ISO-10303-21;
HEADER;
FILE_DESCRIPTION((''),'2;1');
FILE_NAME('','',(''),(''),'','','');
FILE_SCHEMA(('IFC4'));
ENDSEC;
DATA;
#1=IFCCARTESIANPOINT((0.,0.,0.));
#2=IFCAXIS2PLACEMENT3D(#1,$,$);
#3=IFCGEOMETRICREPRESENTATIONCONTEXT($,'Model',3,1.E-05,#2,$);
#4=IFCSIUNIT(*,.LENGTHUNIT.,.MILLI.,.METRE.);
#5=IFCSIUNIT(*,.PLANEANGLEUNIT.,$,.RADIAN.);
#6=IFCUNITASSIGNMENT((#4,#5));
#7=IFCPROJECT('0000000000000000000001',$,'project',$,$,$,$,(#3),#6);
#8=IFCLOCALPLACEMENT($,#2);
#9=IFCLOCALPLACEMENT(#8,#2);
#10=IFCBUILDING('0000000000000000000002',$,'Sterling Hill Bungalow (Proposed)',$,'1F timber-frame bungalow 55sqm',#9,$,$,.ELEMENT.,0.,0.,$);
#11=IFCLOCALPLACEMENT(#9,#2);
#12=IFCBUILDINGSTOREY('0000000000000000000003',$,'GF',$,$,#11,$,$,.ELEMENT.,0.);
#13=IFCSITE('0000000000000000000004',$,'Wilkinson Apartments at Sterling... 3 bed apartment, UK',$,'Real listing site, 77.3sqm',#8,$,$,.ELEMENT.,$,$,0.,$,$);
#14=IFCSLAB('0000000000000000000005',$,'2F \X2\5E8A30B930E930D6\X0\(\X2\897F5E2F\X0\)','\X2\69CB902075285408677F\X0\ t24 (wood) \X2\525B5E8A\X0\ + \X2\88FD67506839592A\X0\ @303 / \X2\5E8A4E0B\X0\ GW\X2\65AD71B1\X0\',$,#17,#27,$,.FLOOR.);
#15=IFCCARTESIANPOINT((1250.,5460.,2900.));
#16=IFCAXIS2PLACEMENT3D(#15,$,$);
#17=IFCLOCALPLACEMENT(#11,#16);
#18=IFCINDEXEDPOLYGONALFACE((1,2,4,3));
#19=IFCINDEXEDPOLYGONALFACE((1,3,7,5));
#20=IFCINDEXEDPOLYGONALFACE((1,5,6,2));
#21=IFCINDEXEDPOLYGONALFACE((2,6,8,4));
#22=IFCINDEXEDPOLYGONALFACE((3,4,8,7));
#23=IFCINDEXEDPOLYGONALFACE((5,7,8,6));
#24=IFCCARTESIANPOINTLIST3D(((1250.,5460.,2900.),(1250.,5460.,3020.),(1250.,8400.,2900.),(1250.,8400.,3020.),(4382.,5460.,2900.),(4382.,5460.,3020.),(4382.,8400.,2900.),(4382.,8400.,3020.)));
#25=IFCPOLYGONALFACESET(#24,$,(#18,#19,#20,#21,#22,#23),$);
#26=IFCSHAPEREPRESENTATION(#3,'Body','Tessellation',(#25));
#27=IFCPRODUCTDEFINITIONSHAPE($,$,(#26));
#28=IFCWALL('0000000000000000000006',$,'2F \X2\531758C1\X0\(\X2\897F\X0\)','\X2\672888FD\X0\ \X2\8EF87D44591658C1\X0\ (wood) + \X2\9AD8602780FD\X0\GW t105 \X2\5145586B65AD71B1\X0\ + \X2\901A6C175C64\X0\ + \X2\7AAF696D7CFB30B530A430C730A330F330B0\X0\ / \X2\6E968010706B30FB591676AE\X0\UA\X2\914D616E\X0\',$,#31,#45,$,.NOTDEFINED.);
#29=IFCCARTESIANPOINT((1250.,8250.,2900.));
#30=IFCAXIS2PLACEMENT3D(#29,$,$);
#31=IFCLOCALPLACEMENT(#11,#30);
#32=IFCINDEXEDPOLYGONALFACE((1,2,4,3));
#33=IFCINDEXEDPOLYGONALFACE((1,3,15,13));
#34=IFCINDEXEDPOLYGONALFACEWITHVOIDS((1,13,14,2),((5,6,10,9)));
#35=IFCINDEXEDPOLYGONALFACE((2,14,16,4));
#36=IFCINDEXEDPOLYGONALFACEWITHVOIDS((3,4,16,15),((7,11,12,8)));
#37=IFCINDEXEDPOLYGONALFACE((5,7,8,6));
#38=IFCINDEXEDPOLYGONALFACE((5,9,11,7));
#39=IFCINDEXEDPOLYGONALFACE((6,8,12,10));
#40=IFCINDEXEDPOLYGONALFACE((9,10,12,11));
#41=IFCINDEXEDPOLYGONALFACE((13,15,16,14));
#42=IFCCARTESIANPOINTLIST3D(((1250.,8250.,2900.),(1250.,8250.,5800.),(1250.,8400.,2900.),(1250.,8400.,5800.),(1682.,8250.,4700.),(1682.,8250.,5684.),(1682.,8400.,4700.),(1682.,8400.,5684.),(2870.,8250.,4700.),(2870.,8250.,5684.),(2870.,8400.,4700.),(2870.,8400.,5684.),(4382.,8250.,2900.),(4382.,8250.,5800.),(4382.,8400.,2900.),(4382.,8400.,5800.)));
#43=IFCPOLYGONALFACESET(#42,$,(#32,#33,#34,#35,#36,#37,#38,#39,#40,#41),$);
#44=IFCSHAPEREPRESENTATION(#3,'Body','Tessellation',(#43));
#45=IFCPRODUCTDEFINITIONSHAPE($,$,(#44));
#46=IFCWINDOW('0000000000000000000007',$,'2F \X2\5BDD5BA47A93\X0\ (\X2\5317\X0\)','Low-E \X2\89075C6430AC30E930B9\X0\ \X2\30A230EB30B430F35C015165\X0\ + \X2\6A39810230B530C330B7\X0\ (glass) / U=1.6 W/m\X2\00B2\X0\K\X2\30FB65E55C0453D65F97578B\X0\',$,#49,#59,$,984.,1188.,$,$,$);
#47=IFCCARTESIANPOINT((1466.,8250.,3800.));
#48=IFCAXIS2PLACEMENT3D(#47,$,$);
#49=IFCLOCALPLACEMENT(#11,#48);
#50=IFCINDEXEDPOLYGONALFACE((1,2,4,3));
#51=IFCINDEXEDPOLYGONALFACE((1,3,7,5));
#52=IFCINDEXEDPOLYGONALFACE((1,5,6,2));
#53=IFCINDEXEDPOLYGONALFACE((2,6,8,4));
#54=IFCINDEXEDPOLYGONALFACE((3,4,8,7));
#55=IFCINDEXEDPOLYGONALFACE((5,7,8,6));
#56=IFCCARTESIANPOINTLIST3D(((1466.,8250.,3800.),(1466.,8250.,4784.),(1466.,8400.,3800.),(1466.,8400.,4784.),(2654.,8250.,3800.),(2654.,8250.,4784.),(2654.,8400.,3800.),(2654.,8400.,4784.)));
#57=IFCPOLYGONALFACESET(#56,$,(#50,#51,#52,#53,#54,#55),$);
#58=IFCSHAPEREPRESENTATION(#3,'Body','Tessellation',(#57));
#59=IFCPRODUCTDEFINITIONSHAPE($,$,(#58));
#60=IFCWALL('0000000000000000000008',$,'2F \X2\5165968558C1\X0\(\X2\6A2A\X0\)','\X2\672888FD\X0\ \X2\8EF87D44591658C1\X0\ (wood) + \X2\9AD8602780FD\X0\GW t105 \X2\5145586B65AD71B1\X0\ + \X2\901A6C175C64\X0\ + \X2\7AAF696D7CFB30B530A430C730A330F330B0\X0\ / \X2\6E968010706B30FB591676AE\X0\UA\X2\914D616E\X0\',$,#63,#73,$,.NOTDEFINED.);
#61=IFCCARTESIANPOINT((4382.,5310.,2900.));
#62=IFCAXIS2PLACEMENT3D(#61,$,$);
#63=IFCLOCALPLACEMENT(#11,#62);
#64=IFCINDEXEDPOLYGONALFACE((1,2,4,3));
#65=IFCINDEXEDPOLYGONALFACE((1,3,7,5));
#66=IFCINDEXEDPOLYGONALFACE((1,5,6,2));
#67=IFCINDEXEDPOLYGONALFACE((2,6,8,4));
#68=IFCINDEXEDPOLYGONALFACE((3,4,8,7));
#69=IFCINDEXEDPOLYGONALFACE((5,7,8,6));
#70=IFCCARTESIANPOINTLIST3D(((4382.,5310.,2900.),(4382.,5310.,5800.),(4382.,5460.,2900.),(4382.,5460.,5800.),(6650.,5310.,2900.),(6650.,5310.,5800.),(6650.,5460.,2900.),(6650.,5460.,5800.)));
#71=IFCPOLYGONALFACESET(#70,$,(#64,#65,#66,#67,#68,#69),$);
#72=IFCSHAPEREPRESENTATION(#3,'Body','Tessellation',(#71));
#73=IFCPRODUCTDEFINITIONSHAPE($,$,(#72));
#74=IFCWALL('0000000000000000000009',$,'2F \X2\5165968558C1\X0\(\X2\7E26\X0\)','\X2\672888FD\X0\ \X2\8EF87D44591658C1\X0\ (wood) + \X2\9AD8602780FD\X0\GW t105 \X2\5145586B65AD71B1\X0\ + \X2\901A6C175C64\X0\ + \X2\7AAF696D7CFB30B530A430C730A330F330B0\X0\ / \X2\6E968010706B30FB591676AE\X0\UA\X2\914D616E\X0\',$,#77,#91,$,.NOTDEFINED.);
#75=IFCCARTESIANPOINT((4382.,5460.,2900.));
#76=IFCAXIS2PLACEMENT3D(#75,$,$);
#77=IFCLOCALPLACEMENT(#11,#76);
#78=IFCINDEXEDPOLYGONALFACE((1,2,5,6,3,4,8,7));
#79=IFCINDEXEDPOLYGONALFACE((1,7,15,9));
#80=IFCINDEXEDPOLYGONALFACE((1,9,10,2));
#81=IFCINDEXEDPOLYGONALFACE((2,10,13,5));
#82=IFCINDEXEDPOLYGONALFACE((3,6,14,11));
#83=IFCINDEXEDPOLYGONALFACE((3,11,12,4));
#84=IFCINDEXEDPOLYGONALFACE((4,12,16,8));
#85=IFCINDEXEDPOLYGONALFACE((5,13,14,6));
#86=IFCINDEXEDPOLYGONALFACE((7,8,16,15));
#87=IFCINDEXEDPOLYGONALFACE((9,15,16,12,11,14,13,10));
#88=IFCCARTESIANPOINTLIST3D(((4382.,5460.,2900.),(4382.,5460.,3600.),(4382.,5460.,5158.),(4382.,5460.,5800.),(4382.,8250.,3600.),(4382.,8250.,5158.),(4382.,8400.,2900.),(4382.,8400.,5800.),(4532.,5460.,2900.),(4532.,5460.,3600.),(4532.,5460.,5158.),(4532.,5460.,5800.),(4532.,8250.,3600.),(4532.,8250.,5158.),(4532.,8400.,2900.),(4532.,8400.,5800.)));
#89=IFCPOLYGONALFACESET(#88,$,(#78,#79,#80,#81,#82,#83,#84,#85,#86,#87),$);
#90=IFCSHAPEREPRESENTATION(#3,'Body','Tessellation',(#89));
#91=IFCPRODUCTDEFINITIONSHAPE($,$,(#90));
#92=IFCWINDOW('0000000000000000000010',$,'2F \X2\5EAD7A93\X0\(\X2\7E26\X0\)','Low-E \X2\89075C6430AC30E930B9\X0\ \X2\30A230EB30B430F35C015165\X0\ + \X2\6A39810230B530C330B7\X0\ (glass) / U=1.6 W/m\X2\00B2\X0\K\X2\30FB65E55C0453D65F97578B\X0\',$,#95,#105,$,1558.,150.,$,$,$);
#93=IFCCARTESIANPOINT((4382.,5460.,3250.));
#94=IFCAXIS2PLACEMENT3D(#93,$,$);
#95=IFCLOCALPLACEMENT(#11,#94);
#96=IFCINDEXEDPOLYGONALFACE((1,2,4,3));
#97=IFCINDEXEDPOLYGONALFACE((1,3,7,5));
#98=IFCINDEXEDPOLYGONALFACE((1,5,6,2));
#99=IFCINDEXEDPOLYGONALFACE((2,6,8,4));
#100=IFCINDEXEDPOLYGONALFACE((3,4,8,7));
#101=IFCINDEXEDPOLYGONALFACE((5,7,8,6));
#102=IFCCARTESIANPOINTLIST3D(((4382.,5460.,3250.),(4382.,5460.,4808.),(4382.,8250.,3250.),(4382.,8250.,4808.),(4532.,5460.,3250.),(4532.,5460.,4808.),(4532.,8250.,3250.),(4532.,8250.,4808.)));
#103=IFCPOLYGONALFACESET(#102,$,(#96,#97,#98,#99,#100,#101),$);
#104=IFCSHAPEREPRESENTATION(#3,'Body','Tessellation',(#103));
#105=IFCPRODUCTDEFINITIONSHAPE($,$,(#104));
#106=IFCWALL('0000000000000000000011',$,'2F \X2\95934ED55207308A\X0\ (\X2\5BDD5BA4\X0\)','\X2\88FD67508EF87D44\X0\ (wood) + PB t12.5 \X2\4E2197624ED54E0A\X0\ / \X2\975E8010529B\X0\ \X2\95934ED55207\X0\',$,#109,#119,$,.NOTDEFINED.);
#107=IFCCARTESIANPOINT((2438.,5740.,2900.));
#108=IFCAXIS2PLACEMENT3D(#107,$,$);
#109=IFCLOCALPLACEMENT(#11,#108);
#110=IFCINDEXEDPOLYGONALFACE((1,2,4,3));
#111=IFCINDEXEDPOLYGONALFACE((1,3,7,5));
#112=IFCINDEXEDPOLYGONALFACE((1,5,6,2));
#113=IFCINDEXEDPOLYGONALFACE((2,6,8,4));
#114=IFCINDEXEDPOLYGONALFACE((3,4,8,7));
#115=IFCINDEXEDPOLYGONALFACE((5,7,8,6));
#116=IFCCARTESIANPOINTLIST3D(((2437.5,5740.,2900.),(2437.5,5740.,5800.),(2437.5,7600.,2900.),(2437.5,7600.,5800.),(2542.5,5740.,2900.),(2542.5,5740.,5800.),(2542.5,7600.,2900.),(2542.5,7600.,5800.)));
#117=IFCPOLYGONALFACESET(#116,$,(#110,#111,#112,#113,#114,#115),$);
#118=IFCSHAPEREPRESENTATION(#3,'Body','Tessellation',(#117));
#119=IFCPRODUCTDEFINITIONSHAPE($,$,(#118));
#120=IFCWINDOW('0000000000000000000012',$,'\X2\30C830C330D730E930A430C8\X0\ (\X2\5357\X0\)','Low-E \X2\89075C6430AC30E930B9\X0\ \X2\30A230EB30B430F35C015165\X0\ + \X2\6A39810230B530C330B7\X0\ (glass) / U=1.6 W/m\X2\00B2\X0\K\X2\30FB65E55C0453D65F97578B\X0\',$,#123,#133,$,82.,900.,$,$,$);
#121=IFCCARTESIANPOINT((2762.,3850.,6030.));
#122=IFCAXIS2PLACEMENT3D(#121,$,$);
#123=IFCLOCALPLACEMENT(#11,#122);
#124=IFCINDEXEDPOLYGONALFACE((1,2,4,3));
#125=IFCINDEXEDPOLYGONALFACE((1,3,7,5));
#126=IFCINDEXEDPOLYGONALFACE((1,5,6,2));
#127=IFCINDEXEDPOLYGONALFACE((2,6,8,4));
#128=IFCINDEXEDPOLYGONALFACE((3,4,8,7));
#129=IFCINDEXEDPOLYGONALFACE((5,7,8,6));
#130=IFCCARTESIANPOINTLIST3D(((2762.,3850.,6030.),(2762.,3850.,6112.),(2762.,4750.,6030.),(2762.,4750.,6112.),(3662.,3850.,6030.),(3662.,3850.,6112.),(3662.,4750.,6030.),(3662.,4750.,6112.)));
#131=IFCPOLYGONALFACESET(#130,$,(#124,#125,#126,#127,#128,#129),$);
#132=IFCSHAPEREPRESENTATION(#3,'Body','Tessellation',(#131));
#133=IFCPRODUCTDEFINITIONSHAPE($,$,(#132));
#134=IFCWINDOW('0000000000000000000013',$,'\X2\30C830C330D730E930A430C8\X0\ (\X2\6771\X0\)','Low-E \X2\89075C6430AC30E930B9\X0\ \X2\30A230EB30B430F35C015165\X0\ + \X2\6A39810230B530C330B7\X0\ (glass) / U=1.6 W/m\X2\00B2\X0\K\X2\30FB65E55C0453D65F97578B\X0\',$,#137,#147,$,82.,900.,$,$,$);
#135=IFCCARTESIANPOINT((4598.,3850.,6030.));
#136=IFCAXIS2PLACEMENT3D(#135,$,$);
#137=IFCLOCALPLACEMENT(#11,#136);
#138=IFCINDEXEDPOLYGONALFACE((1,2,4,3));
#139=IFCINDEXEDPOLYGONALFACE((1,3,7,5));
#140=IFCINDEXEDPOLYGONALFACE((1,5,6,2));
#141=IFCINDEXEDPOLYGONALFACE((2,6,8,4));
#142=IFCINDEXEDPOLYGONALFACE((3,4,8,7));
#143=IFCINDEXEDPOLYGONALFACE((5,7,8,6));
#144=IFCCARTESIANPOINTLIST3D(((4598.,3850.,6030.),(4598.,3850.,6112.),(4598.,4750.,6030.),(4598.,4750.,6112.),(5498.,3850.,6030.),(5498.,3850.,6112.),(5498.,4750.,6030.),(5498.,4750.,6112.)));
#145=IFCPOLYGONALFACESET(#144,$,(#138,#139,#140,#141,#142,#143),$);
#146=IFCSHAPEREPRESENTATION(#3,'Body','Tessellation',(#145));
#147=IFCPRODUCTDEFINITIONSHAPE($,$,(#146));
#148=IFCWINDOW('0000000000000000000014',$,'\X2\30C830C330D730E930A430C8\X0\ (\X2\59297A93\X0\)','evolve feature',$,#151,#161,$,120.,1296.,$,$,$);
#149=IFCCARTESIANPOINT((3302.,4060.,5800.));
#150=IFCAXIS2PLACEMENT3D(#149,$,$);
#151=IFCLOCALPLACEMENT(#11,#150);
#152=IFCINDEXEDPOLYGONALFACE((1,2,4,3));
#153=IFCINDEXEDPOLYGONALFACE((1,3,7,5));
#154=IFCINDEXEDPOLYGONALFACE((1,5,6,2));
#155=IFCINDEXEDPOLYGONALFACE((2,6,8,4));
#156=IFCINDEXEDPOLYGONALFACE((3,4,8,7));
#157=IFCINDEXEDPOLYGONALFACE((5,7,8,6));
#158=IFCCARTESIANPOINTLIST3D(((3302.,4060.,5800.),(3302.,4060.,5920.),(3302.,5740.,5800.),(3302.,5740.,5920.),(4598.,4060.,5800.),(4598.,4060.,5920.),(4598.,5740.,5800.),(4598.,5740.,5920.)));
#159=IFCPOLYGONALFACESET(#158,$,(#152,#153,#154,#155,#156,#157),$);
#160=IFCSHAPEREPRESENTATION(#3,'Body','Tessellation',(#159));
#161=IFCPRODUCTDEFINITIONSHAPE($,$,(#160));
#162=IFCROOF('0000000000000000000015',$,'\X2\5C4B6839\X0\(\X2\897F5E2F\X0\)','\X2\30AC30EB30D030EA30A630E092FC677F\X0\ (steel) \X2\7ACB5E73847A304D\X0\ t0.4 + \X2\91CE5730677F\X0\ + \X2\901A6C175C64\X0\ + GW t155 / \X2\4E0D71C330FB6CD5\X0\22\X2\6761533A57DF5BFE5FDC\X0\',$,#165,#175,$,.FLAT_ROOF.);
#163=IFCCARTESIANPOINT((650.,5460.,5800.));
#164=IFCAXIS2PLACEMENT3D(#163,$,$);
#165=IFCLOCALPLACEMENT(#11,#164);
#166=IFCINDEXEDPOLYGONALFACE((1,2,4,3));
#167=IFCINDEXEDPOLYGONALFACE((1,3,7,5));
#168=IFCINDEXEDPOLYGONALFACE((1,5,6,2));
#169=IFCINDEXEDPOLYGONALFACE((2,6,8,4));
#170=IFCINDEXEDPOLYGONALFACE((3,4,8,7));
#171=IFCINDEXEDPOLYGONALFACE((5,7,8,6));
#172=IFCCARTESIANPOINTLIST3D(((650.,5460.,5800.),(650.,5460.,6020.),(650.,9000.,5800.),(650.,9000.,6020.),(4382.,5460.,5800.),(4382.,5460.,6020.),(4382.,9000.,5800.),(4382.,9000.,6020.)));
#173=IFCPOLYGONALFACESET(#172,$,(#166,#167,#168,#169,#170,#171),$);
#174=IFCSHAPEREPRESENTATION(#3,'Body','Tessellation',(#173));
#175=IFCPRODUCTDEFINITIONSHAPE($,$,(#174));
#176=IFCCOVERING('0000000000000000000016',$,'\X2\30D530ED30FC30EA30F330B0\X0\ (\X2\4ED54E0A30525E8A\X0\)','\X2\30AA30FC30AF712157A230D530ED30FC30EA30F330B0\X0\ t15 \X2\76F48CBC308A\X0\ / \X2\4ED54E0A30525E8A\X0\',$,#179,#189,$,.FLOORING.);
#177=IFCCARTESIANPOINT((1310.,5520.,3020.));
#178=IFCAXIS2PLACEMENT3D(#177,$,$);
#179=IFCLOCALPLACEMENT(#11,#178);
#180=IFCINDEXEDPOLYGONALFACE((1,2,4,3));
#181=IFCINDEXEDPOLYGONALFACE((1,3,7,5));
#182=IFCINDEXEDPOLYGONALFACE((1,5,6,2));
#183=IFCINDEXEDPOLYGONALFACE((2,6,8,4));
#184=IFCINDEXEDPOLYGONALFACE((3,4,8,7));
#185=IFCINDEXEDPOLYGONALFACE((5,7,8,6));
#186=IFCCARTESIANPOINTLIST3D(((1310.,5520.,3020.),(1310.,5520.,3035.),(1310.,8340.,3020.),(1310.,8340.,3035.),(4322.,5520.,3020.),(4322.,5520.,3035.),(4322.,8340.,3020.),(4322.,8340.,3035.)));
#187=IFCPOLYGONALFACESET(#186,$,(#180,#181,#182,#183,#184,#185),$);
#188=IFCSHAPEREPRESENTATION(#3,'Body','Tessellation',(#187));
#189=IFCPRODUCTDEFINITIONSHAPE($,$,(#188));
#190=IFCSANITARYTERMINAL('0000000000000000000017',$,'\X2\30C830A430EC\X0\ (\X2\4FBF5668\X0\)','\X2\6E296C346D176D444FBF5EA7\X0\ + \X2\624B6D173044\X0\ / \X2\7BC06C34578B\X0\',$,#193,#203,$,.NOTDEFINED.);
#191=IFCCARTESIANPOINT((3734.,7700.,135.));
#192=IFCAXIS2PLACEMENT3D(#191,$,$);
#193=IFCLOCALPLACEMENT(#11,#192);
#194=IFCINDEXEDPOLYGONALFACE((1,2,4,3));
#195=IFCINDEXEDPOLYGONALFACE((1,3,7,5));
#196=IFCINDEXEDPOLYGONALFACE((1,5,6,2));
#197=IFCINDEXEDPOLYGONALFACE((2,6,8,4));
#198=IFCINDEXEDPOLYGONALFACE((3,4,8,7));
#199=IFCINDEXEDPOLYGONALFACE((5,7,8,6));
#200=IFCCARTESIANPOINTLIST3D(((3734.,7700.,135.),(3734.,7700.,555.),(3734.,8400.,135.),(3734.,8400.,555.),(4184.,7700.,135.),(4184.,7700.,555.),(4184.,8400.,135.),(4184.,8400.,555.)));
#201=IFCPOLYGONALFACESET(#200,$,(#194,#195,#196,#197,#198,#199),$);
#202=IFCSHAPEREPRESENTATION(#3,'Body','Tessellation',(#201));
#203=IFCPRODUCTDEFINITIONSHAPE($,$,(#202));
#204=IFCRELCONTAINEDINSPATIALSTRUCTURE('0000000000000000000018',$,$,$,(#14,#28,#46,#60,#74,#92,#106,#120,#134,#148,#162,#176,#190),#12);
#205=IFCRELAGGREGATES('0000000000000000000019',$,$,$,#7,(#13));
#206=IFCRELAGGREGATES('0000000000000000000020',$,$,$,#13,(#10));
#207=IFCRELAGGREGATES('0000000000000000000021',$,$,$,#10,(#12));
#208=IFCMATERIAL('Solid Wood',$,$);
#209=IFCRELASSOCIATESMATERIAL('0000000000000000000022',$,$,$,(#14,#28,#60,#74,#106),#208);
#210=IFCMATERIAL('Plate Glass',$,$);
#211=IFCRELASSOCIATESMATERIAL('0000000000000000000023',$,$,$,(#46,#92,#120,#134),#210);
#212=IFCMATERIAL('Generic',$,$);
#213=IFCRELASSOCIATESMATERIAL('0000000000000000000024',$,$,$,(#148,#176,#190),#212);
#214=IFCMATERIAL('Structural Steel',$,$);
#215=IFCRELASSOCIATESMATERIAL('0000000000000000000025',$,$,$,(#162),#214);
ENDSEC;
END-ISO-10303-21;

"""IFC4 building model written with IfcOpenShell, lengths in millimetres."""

from ifc_helpers import new_model, si_unit, frame, frame_2d, origin, place, context, project, spatial, rectangle, extrude, material, element, fill, save


model = new_model("IFC4")

# Units and contexts
model_context = context("Model", 3, precision=1e-05, world=origin())
ifc_project = project(units=[si_unit("LENGTHUNIT", "METRE", prefix="MILLI"), si_unit("PLANEANGLEUNIT", "RADIAN")], contexts=[model_context])

# Site, building, storey
site_placement = place(None, origin())
site = spatial("IfcSite", under=ifc_project, at=site_placement, Name="Wilkinson Apartments at Sterling... 3 bed apartment, UK", ObjectType="Real listing site, 77.3sqm", CompositionType="ELEMENT", RefElevation=0.0)
building_placement = place(site_placement, origin())
building = spatial("IfcBuilding", under=site, at=building_placement, Name="Sterling Hill Bungalow (Proposed)", ObjectType="1F timber-frame bungalow 55sqm", CompositionType="ELEMENT", ElevationOfRefHeight=0.0, ElevationOfTerrain=0.0)
storey_placement = place(building_placement, origin())
storey = spatial("IfcBuildingStorey", under=building, at=storey_placement, Name="GF", CompositionType="ELEMENT", Elevation=0.0)

# Slab
ifc_material_1 = material(Name="Solid Wood")
slab_placement = place(storey_placement, frame((1250.0, 5460.0, 2900.0)))
element("IfcSlab", 1, at=slab_placement, inside=storey, material=ifc_material_1, Name="2F 床スラブ(西帯)", Description="構造用合板 t24 (wood) 剛床 + 製材根太 @303 / 床下 GW断熱", PredefinedType="FLOOR", context=model_context, shape_type="SweptSolid", body=[
    extrude(rectangle(XDim=3132.0, YDim=2940.0, at=frame_2d((1566.0, 1470.0))), frame((1250.0, 5460.0, 2900.0)), (0.0, 0.0, 1.0), 120.0),
])

# Wall, opening, window
wall_1_placement = place(storey_placement, frame((1250.0, 8250.0, 2900.0)))
wall_1 = element("IfcWall", 2, at=wall_1_placement, inside=storey, material=ifc_material_1, Name="2F 北壁(西)", Description="木製 軸組外壁 (wood) + 高性能GW t105 充填断熱 + 通気層 + 窯業系サイディング / 準耐火・外皮UA配慮", PredefinedType="NOTDEFINED", context=model_context, shape_type="SweptSolid", body=[
    extrude(rectangle(XDim=3132.0, YDim=150.0, at=frame_2d((1566.0, 75.0))), frame((1250.0, 8250.0, 2900.0)), (0.0, 0.0, 1.0), 2900.0),
])
opening_1_placement = place(storey_placement, frame((1466.0, 8250.0, 3800.0)))
opening_1 = element("IfcOpeningElement", 3, at=opening_1_placement, cuts=wall_1, PredefinedType="NOTDEFINED", context=model_context, shape_type="SweptSolid", body=[
    extrude(rectangle(XDim=1188.0, YDim=150.0, at=frame_2d((594.0, 75.0))), frame((1466.0, 8250.0, 3800.0)), (0.0, 0.0, 1.0), 984.0),
])
ifc_material_2 = material(Name="Plate Glass")
window_1_placement = place(storey_placement, frame((1466.0, 8250.0, 3800.0)))
window_1 = element("IfcWindow", 4, at=window_1_placement, inside=storey, material=ifc_material_2, Name="2F 寝室窓 (北)", Description="Low-E 複層ガラス アルゴン封入 + 樹脂サッシ (glass) / U=1.6 W/m²K・日射取得型", OverallHeight=984.0, OverallWidth=1188.0, context=model_context, shape_type="SweptSolid", body=[
    extrude(rectangle(XDim=1188.0, YDim=150.0, at=frame_2d((594.0, 75.0))), frame((1466.0, 8250.0, 3800.0)), (0.0, 0.0, 1.0), 984.0),
])
fill(opening_1, window_1)

# Wall
wall_2_placement = place(storey_placement, frame((4382.0, 5310.0, 2900.0)))
element("IfcWall", 5, at=wall_2_placement, inside=storey, material=ifc_material_1, Name="2F 入隅壁(横)", Description="木製 軸組外壁 (wood) + 高性能GW t105 充填断熱 + 通気層 + 窯業系サイディング / 準耐火・外皮UA配慮", PredefinedType="NOTDEFINED", context=model_context, shape_type="SweptSolid", body=[
    extrude(rectangle(XDim=2268.0, YDim=150.0, at=frame_2d((1134.0, 75.0))), frame((4382.0, 5310.0, 2900.0)), (0.0, 0.0, 1.0), 2900.0),
])

# Wall, opening, window
wall_3_placement = place(storey_placement, frame((4382.0, 5460.0, 2900.0)))
wall_3 = element("IfcWall", 6, at=wall_3_placement, inside=storey, material=ifc_material_1, Name="2F 入隅壁(縦)", Description="木製 軸組外壁 (wood) + 高性能GW t105 充填断熱 + 通気層 + 窯業系サイディング / 準耐火・外皮UA配慮", PredefinedType="NOTDEFINED", context=model_context, shape_type="SweptSolid", body=[
    extrude(rectangle(XDim=150.0, YDim=2940.0, at=frame_2d((75.0, 1470.0))), frame((4382.0, 5460.0, 2900.0)), (0.0, 0.0, 1.0), 2900.0),
])
opening_2_placement = place(storey_placement, frame((4382.0, 5460.0, 3250.0)))
opening_2 = element("IfcOpeningElement", 7, at=opening_2_placement, cuts=wall_3, PredefinedType="NOTDEFINED", context=model_context, shape_type="SweptSolid", body=[
    extrude(rectangle(XDim=150.0, YDim=2790.0, at=frame_2d((75.0, 1395.0))), frame((4382.0, 5460.0, 3250.0)), (0.0, 0.0, 1.0), 1558.0),
])
window_2_placement = place(storey_placement, frame((4382.0, 5460.0, 3250.0)))
window_2 = element("IfcWindow", 8, at=window_2_placement, inside=storey, material=ifc_material_2, Name="2F 庭窓(縦)", Description="Low-E 複層ガラス アルゴン封入 + 樹脂サッシ (glass) / U=1.6 W/m²K・日射取得型", OverallHeight=1558.0, OverallWidth=150.0, context=model_context, shape_type="SweptSolid", body=[
    extrude(rectangle(XDim=150.0, YDim=2790.0, at=frame_2d((75.0, 1395.0))), frame((4382.0, 5460.0, 3250.0)), (0.0, 0.0, 1.0), 1558.0),
])
fill(opening_2, window_2)

# Wall
wall_4_placement = place(storey_placement, frame((2438.0, 5740.0, 2900.0)))
element("IfcWall", 9, at=wall_4_placement, inside=storey, material=ifc_material_1, Name="2F 間仕切り (寝室)", Description="製材軸組 (wood) + PB t12.5 両面仕上 / 非耐力 間仕切", PredefinedType="NOTDEFINED", context=model_context, shape_type="SweptSolid", body=[
    extrude(rectangle(XDim=105.0, YDim=1860.0, at=frame_2d((52.0, 930.0))), frame((2438.0, 5740.0, 2900.0)), (0.0, 0.0, 1.0), 2900.0),
])

# Windows
window_3_placement = place(storey_placement, frame((2762.0, 3850.0, 6030.0)))
element("IfcWindow", 10, at=window_3_placement, inside=storey, material=ifc_material_2, Name="トップライト (南)", Description="Low-E 複層ガラス アルゴン封入 + 樹脂サッシ (glass) / U=1.6 W/m²K・日射取得型", OverallHeight=82.0, OverallWidth=900.0, context=model_context, shape_type="SweptSolid", body=[
    extrude(rectangle(XDim=900.0, YDim=900.0, at=frame_2d((450.0, 450.0))), frame((2762.0, 3850.0, 6030.0)), (0.0, 0.0, 1.0), 82.0),
])
window_4_placement = place(storey_placement, frame((4598.0, 3850.0, 6030.0)))
element("IfcWindow", 11, at=window_4_placement, inside=storey, material=ifc_material_2, Name="トップライト (東)", Description="Low-E 複層ガラス アルゴン封入 + 樹脂サッシ (glass) / U=1.6 W/m²K・日射取得型", OverallHeight=82.0, OverallWidth=900.0, context=model_context, shape_type="SweptSolid", body=[
    extrude(rectangle(XDim=900.0, YDim=900.0, at=frame_2d((450.0, 450.0))), frame((4598.0, 3850.0, 6030.0)), (0.0, 0.0, 1.0), 82.0),
])
ifc_material_3 = material(Name="Generic")
window_5_placement = place(storey_placement, frame((3302.0, 4060.0, 5800.0)))
element("IfcWindow", 12, at=window_5_placement, inside=storey, material=ifc_material_3, Name="トップライト (天窓)", Description="evolve feature", OverallHeight=120.0, OverallWidth=1296.0, context=model_context, shape_type="SweptSolid", body=[
    extrude(rectangle(XDim=1296.0, YDim=1680.0, at=frame_2d((648.0, 840.0))), frame((3302.0, 4060.0, 5800.0)), (0.0, 0.0, 1.0), 120.0),
])

# Roof
ifc_material_4 = material(Name="Structural Steel")
for number, where, name in (
    (13, (650.0, 5460.0, 5800.0), "屋根(西帯)"),
):
    element("IfcRoof", number, at=place(storey_placement, frame(where)), inside=storey, material=ifc_material_4, Name=name, Description="ガルバリウム鋼板 (steel) 立平葺き t0.4 + 野地板 + 通気層 + GW t155 / 不燃・法22条区域対応", PredefinedType="FLAT_ROOF", context=model_context, shape_type="SweptSolid", body=[
        extrude(rectangle(XDim=3732.0, YDim=3540.0, at=frame_2d((1866.0, 1770.0))), frame((650.0, 5460.0, 5800.0)), (0.0, 0.0, 1.0), 220.0),
    ])

# Covering
covering_placement = place(storey_placement, frame((1310.0, 5520.0, 3020.0)))
element("IfcCovering", 14, at=covering_placement, inside=storey, material=ifc_material_3, Name="フローリング (仕上げ床)", Description="オーク無垢フローリング t15 直貼り / 仕上げ床", PredefinedType="FLOORING", context=model_context, shape_type="SweptSolid", body=[
    extrude(rectangle(XDim=3012.0, YDim=2820.0, at=frame_2d((1506.0, 1410.0))), frame((1310.0, 5520.0, 3020.0)), (0.0, 0.0, 1.0), 15.0),
])

# Sanitary terminal
sanitary_terminal_placement = place(storey_placement, frame((3734.0, 7700.0, 135.0)))
element("IfcSanitaryTerminal", 15, at=sanitary_terminal_placement, inside=storey, material=ifc_material_3, Name="トイレ (便器)", Description="温水洗浄便座 + 手洗い / 節水型", PredefinedType="NOTDEFINED", context=model_context, shape_type="SweptSolid", body=[
    extrude(rectangle(XDim=450.0, YDim=700.0, at=frame_2d((225.0, 350.0))), frame((3734.0, 7700.0, 135.0)), (0.0, 0.0, 1.0), 420.0),
])

save(model, "model.ifc")
